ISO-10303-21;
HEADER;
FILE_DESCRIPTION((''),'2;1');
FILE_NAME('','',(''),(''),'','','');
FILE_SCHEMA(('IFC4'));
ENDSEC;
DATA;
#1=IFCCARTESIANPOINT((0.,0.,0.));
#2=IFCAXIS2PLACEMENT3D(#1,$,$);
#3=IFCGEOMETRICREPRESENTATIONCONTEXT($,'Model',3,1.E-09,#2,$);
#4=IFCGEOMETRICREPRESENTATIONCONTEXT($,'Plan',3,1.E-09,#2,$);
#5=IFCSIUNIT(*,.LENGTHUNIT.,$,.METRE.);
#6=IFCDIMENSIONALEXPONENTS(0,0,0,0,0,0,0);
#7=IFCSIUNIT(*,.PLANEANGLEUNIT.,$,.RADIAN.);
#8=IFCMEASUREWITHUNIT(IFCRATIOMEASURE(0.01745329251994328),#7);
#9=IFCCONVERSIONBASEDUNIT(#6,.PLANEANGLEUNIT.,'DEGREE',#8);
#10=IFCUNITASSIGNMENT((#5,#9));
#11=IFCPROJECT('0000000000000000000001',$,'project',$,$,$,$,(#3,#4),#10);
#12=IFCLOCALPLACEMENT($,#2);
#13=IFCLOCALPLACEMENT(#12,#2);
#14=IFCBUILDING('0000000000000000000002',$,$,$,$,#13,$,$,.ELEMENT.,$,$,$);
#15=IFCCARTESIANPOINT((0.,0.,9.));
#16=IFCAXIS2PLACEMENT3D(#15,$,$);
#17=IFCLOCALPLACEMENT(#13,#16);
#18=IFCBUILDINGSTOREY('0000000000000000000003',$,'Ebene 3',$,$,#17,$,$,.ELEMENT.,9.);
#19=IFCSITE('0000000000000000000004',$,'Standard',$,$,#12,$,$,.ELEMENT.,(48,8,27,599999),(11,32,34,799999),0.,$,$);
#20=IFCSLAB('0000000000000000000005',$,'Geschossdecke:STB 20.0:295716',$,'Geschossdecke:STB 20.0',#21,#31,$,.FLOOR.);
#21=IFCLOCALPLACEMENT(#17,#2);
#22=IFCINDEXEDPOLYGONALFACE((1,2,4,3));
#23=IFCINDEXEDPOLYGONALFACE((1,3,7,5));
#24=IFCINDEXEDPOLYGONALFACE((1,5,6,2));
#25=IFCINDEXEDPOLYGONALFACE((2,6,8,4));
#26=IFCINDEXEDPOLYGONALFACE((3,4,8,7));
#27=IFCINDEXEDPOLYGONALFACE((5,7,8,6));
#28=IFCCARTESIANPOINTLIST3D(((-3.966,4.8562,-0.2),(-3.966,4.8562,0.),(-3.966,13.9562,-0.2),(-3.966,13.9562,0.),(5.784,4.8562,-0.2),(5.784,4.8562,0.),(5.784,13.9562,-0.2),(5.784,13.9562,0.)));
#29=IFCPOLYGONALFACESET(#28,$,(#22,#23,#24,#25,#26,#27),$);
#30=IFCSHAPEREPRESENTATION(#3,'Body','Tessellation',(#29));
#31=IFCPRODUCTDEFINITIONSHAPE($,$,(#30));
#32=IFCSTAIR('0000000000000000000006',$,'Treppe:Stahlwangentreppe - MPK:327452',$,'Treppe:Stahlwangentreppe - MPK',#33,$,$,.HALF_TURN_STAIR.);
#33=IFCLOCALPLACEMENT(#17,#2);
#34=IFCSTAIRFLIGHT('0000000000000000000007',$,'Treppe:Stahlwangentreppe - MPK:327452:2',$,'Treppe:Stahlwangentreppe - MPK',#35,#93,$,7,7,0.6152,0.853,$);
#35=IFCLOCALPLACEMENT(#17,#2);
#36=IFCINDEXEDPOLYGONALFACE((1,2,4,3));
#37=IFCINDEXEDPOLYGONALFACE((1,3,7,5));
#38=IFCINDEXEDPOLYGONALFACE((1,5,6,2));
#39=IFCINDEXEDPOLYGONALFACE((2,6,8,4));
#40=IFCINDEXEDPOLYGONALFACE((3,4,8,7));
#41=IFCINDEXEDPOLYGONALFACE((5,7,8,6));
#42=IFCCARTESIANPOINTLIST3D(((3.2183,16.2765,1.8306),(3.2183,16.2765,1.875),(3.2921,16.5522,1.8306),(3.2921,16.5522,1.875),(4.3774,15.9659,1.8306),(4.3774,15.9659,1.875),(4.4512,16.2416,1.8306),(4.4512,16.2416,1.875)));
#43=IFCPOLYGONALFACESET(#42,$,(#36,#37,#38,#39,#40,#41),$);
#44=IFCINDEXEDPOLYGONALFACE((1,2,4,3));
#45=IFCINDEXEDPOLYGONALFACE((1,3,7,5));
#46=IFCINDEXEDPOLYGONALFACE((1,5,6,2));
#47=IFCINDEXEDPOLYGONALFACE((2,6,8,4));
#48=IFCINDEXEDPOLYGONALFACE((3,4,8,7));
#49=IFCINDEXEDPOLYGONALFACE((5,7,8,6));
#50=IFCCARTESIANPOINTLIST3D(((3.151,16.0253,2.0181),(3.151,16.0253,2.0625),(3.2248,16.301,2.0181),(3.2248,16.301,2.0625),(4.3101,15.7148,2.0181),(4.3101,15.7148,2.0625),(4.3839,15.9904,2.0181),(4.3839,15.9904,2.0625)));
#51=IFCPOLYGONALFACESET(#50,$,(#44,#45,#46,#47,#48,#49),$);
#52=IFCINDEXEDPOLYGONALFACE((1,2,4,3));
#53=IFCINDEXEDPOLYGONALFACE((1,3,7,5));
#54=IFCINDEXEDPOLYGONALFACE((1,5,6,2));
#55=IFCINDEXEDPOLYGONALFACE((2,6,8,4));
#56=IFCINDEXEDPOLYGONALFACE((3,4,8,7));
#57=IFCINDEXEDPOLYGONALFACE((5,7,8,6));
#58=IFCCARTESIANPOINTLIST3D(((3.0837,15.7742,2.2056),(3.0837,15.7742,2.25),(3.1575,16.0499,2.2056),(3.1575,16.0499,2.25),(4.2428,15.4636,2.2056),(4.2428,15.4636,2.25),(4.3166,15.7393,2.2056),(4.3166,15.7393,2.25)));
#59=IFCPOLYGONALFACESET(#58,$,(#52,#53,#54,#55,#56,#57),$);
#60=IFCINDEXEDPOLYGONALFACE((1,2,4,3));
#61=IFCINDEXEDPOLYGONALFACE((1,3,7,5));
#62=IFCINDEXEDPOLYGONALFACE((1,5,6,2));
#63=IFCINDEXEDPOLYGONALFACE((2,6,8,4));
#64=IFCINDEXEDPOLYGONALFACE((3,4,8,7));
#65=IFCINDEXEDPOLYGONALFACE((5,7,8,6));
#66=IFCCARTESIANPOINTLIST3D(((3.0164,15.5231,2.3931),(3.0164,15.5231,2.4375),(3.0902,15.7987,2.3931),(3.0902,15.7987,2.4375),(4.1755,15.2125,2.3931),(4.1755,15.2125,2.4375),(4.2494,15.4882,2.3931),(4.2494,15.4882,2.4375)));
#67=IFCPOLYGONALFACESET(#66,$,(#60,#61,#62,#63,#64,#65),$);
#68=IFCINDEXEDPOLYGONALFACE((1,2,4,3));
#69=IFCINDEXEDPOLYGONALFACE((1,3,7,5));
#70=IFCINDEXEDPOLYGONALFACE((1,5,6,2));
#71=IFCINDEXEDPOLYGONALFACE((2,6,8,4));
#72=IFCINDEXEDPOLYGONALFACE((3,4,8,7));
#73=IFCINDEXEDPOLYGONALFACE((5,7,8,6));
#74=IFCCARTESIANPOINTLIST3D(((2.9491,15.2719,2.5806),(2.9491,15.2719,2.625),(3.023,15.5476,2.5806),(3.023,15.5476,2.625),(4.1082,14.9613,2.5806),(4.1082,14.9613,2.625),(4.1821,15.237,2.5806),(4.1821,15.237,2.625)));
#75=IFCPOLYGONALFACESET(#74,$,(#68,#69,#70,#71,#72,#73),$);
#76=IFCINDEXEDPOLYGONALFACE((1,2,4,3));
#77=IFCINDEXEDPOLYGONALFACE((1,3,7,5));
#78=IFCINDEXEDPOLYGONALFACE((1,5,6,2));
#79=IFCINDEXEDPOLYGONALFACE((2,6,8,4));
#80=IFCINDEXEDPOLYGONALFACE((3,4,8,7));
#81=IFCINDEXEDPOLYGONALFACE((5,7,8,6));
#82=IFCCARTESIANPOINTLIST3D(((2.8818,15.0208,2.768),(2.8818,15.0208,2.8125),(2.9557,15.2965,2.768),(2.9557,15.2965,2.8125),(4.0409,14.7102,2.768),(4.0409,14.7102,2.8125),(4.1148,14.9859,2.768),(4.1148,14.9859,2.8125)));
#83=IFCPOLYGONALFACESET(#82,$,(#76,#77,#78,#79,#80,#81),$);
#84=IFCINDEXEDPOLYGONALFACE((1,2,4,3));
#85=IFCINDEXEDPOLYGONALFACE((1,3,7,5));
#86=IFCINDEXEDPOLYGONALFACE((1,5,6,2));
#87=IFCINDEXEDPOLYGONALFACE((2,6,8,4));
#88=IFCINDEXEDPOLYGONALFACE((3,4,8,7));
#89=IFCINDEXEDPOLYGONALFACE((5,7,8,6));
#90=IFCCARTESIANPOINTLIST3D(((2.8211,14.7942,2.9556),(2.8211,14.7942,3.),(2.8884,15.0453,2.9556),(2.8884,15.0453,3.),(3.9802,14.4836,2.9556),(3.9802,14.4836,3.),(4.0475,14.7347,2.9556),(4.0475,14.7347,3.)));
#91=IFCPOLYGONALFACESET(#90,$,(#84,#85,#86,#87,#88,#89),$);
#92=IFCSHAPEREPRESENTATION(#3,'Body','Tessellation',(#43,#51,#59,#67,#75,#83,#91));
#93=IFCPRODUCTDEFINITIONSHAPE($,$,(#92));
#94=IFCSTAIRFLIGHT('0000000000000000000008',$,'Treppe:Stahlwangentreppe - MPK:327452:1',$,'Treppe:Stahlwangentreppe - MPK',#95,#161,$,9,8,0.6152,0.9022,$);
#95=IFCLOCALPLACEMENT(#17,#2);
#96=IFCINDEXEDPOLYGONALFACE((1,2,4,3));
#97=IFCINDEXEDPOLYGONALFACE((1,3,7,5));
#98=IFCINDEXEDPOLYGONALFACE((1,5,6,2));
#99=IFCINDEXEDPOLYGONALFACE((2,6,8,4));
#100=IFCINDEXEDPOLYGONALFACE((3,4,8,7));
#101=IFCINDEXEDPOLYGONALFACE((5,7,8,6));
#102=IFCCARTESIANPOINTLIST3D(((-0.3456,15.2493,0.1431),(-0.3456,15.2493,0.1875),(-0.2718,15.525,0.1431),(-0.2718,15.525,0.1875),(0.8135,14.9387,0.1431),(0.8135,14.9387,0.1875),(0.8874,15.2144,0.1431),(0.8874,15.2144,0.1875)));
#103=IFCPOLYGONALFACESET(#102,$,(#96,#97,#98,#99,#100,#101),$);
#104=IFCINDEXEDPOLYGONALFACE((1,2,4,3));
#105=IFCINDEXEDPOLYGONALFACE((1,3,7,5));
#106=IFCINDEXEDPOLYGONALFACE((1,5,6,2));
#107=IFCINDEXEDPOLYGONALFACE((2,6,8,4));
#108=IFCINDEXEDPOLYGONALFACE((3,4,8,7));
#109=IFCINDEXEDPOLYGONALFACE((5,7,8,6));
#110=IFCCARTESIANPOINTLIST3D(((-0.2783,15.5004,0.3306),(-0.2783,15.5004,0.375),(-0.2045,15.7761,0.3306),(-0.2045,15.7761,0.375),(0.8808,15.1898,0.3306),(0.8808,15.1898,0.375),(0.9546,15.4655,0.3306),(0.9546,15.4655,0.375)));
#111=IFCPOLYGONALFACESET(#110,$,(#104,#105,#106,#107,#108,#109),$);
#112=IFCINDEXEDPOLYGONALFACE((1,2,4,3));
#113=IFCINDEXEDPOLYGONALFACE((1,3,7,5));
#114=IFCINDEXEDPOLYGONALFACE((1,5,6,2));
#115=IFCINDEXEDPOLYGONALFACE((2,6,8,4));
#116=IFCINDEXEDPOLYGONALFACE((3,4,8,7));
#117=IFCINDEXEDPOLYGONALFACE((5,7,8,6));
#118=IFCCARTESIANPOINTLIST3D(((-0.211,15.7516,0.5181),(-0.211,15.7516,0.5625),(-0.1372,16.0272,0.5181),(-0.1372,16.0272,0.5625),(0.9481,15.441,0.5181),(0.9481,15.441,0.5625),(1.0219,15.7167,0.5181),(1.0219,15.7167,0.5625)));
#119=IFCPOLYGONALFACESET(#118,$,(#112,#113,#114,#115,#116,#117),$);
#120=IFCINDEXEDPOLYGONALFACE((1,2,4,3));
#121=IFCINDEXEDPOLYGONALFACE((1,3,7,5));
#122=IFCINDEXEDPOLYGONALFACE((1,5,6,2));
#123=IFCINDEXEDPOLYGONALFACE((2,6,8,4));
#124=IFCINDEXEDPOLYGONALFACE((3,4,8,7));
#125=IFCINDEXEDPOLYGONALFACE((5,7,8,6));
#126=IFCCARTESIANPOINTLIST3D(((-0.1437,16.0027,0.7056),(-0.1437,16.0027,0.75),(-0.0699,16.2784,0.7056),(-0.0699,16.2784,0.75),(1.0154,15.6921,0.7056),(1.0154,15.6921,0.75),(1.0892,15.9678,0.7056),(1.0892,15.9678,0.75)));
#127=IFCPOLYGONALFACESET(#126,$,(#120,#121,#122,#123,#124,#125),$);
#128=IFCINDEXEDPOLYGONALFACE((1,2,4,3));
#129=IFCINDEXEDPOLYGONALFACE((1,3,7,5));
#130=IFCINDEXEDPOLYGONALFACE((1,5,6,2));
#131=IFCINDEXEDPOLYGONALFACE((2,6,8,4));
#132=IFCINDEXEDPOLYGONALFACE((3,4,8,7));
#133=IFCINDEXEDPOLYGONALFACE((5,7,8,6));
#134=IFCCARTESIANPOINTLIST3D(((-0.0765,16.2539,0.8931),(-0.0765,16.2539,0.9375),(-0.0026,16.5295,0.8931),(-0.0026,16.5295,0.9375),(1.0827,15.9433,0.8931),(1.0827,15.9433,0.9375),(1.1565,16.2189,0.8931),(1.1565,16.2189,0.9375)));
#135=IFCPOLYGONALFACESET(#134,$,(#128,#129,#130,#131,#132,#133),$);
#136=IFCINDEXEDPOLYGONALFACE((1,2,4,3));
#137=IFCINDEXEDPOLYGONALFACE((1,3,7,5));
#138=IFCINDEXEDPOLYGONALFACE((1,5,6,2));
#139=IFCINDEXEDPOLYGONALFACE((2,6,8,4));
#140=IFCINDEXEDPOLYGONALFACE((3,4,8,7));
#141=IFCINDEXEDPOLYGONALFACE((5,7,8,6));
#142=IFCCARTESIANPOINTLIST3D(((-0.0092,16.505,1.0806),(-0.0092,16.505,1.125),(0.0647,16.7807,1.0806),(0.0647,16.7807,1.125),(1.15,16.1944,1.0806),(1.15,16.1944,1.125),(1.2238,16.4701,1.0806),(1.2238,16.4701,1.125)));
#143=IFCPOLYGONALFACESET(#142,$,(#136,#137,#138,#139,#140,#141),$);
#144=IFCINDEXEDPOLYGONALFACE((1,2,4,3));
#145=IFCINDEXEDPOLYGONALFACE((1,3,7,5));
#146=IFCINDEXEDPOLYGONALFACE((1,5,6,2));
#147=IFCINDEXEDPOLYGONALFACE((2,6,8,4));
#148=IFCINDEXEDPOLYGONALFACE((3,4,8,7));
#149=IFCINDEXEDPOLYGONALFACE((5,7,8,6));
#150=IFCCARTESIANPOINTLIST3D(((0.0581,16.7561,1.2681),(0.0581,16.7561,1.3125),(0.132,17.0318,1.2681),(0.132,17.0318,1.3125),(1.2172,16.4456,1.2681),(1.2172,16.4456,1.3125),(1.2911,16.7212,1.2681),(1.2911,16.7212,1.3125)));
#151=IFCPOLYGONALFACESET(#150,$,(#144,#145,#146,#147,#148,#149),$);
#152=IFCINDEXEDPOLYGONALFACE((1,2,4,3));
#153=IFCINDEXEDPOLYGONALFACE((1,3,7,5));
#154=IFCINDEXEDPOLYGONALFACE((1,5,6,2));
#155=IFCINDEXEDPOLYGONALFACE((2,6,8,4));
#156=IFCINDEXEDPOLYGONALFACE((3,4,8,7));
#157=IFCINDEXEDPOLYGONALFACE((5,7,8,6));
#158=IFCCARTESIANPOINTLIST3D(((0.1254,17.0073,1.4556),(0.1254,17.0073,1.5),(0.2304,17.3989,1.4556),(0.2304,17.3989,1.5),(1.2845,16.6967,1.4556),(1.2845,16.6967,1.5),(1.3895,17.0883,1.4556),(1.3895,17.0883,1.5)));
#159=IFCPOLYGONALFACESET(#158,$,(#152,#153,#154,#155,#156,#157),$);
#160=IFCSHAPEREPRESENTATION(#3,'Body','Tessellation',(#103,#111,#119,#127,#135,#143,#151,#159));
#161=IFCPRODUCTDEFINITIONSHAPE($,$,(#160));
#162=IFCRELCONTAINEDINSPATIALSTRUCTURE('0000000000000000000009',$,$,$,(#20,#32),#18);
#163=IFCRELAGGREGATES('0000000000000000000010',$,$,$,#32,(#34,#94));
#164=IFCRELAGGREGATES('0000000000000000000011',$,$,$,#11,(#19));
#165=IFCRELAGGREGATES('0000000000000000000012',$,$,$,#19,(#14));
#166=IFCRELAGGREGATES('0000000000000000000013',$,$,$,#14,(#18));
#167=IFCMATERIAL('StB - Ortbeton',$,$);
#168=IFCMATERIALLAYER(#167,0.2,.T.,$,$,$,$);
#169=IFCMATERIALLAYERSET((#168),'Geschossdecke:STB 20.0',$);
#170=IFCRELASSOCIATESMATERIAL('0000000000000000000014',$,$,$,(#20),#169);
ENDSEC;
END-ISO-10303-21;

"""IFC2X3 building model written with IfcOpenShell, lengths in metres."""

from ifc_helpers import new_model, entity, si_unit, converted_unit, frame, frame_2d, origin, origin_2d_with_axis, place, context, project, spatial, rectangle, extrude, material, layer, layer_set, layer_usage, element, aggregate, save


model = new_model("IFC2X3")

# Units and contexts
model_context = context("Model", 3, precision=1e-09, world=origin())
plan_context = context("Plan", 3, precision=1e-09, world=origin())
ifc_project = project(units=[si_unit("LENGTHUNIT", "METRE"), converted_unit("PLANEANGLEUNIT", "DEGREE", entity("IfcRatioMeasure", 0.01745329251994328), si_unit("PLANEANGLEUNIT", "RADIAN"), dimensions=[0, 0, 0, 0, 0, 0, 0])], contexts=[model_context, plan_context])

# Site, building, storey
site_placement = place(None, origin())
site = spatial("IfcSite", under=ifc_project, at=site_placement, Name="Standard", CompositionType="ELEMENT", RefLatitude=(48, 8, 27, 599999), RefLongitude=(11, 32, 34, 799999), RefElevation=0.0)
building_placement = place(site_placement, origin())
building = spatial("IfcBuilding", under=site, at=building_placement, CompositionType="ELEMENT")
storey_placement = place(building_placement, frame((0.0, 0.0, 9.0)))
storey = spatial("IfcBuildingStorey", under=building, at=storey_placement, Name="Ebene 3", CompositionType="ELEMENT", Elevation=9.0)

# Slab
ifc_material = material(Name="StB - Ortbeton")
ifc_layer = layer(ifc_material, 0.2, ventilated=True)
ifc_layer_set = layer_set([ifc_layer], Name="Geschossdecke:STB 20.0")
ifc_layer_usage = layer_usage(ifc_layer_set, "AXIS3", "POSITIVE", 0.0)
slab_1_placement = place(storey_placement, frame((-3.966, 4.8562, -0.2)))
element("IfcSlab", 1, at=slab_1_placement, inside=storey, material=ifc_layer_usage, Name="Geschossdecke:STB 20.0:295716", ObjectType="Geschossdecke:STB 20.0", PredefinedType="FLOOR", context=model_context, shape_type="SweptSolid", body=[
    extrude(rectangle(XDim=9.1, YDim=9.75, at=frame_2d((0.0, 0.0), x_axis=(0.0, -1.0))), frame((4.875, 4.55, 0.2), z_axis=(0.0, 0.0, -1.0), x_axis=(-1.0, 0.0, 0.0)), (0.0, 0.0, 1.0), 0.2),
])

# Stair, stair flights
stair_placement = place(storey_placement, origin())
stair = element("IfcStair", 2, at=stair_placement, inside=storey, Name="Treppe:Stahlwangentreppe - MPK:327452", ObjectType="Treppe:Stahlwangentreppe - MPK", ShapeType="HALF_TURN_STAIR")
stair_flight_1_placement = place(storey_placement, origin())
stair_flight_1 = element("IfcStairFlight", 3, at=stair_flight_1_placement, Name="Treppe:Stahlwangentreppe - MPK:327452:2", ObjectType="Treppe:Stahlwangentreppe - MPK", NumberOfRiser=7, NumberOfTreads=7, RiserHeight=0.6152, TreadLength=0.853, context=model_context, shape_type="SweptSolid", body=[
    extrude(rectangle(XDim=0.2854, YDim=1.2, at=origin_2d_with_axis()), frame((3.8347, 16.259, 1.8305), z_axis=(0.0, 0.0, 1.0), x_axis=(0.258819, 0.965926, 0.0)), (0.0, 0.0, 1.0), 0.0444),
    extrude(rectangle(XDim=0.2854, YDim=1.2, at=origin_2d_with_axis()), frame((3.7675, 16.0079, 2.0181), z_axis=(0.0, 0.0, 1.0), x_axis=(0.258819, 0.965926, 0.0)), (0.0, 0.0, 1.0), 0.0444),
    extrude(rectangle(XDim=0.2854, YDim=1.2, at=origin_2d_with_axis()), frame((3.7002, 15.7568, 2.2056), z_axis=(0.0, 0.0, 1.0), x_axis=(0.258819, 0.965926, 0.0)), (0.0, 0.0, 1.0), 0.0444),
    extrude(rectangle(XDim=0.2854, YDim=1.2, at=origin_2d_with_axis()), frame((3.6329, 15.5056, 2.3931), z_axis=(0.0, 0.0, 1.0), x_axis=(0.258819, 0.965926, 0.0)), (0.0, 0.0, 1.0), 0.0444),
    extrude(rectangle(XDim=0.2854, YDim=1.2, at=origin_2d_with_axis()), frame((3.5656, 15.2545, 2.5806), z_axis=(0.0, 0.0, 1.0), x_axis=(0.258819, 0.965926, 0.0)), (0.0, 0.0, 1.0), 0.0445),
    extrude(rectangle(XDim=0.2854, YDim=1.2, at=origin_2d_with_axis()), frame((3.4983, 15.0033, 2.768), z_axis=(0.0, 0.0, 1.0), x_axis=(0.258819, 0.965926, 0.0)), (0.0, 0.0, 1.0), 0.0445),
    extrude(rectangle(XDim=0.26, YDim=1.2, at=origin_2d_with_axis()), frame((3.4343, 14.7645, 2.9556), z_axis=(0.0, 0.0, 1.0), x_axis=(0.258819, 0.965926, 0.0)), (0.0, 0.0, 1.0), 0.0445),
])
stair_flight_2_placement = place(storey_placement, origin())
stair_flight_2 = element("IfcStairFlight", 4, at=stair_flight_2_placement, Name="Treppe:Stahlwangentreppe - MPK:327452:1", ObjectType="Treppe:Stahlwangentreppe - MPK", NumberOfRiser=9, NumberOfTreads=8, RiserHeight=0.6152, TreadLength=0.9022, context=model_context, shape_type="SweptSolid", body=[
    extrude(rectangle(XDim=0.2854, YDim=1.2, at=origin_2d_with_axis()), frame((0.2709, 15.2318, 0.1431), z_axis=(0.0, 0.0, 1.0), x_axis=(-0.258819, -0.965926, 0.0)), (0.0, 0.0, 1.0), 0.0445),
    extrude(rectangle(XDim=0.2854, YDim=1.2, at=origin_2d_with_axis()), frame((0.3382, 15.483, 0.3306), z_axis=(0.0, 0.0, 1.0), x_axis=(-0.258819, -0.965926, 0.0)), (0.0, 0.0, 1.0), 0.0445),
    extrude(rectangle(XDim=0.2854, YDim=1.2, at=origin_2d_with_axis()), frame((0.4055, 15.7341, 0.518), z_axis=(0.0, 0.0, 1.0), x_axis=(-0.258819, -0.965926, 0.0)), (0.0, 0.0, 1.0), 0.0445),
    extrude(rectangle(XDim=0.2854, YDim=1.2, at=origin_2d_with_axis()), frame((0.4727, 15.9853, 0.7055), z_axis=(0.0, 0.0, 1.0), x_axis=(-0.258819, -0.965926, 0.0)), (0.0, 0.0, 1.0), 0.0445),
    extrude(rectangle(XDim=0.2854, YDim=1.2, at=origin_2d_with_axis()), frame((0.54, 16.2364, 0.893), z_axis=(0.0, 0.0, 1.0), x_axis=(-0.258819, -0.965926, 0.0)), (0.0, 0.0, 1.0), 0.0445),
    extrude(rectangle(XDim=0.2854, YDim=1.2, at=origin_2d_with_axis()), frame((0.6073, 16.4875, 1.0805), z_axis=(0.0, 0.0, 1.0), x_axis=(-0.258819, -0.965926, 0.0)), (0.0, 0.0, 1.0), 0.0445),
    extrude(rectangle(XDim=0.2854, YDim=1.2, at=origin_2d_with_axis()), frame((0.6746, 16.7387, 1.268), z_axis=(0.0, 0.0, 1.0), x_axis=(-0.258819, -0.965926, 0.0)), (0.0, 0.0, 1.0), 0.0444),
    extrude(rectangle(XDim=0.4054, YDim=1.2, at=frame_2d((0.0355, 0.12), x_axis=(1.0, 0.0))), frame((0.6507, 17.1131, 1.4555), z_axis=(0.0, 0.0, 1.0), x_axis=(-0.258819, -0.965926, 0.0)), (0.0, 0.0, 1.0), 0.0444),
])
aggregate(stair, [stair_flight_1, stair_flight_2])

save(model, "model.ifc")
